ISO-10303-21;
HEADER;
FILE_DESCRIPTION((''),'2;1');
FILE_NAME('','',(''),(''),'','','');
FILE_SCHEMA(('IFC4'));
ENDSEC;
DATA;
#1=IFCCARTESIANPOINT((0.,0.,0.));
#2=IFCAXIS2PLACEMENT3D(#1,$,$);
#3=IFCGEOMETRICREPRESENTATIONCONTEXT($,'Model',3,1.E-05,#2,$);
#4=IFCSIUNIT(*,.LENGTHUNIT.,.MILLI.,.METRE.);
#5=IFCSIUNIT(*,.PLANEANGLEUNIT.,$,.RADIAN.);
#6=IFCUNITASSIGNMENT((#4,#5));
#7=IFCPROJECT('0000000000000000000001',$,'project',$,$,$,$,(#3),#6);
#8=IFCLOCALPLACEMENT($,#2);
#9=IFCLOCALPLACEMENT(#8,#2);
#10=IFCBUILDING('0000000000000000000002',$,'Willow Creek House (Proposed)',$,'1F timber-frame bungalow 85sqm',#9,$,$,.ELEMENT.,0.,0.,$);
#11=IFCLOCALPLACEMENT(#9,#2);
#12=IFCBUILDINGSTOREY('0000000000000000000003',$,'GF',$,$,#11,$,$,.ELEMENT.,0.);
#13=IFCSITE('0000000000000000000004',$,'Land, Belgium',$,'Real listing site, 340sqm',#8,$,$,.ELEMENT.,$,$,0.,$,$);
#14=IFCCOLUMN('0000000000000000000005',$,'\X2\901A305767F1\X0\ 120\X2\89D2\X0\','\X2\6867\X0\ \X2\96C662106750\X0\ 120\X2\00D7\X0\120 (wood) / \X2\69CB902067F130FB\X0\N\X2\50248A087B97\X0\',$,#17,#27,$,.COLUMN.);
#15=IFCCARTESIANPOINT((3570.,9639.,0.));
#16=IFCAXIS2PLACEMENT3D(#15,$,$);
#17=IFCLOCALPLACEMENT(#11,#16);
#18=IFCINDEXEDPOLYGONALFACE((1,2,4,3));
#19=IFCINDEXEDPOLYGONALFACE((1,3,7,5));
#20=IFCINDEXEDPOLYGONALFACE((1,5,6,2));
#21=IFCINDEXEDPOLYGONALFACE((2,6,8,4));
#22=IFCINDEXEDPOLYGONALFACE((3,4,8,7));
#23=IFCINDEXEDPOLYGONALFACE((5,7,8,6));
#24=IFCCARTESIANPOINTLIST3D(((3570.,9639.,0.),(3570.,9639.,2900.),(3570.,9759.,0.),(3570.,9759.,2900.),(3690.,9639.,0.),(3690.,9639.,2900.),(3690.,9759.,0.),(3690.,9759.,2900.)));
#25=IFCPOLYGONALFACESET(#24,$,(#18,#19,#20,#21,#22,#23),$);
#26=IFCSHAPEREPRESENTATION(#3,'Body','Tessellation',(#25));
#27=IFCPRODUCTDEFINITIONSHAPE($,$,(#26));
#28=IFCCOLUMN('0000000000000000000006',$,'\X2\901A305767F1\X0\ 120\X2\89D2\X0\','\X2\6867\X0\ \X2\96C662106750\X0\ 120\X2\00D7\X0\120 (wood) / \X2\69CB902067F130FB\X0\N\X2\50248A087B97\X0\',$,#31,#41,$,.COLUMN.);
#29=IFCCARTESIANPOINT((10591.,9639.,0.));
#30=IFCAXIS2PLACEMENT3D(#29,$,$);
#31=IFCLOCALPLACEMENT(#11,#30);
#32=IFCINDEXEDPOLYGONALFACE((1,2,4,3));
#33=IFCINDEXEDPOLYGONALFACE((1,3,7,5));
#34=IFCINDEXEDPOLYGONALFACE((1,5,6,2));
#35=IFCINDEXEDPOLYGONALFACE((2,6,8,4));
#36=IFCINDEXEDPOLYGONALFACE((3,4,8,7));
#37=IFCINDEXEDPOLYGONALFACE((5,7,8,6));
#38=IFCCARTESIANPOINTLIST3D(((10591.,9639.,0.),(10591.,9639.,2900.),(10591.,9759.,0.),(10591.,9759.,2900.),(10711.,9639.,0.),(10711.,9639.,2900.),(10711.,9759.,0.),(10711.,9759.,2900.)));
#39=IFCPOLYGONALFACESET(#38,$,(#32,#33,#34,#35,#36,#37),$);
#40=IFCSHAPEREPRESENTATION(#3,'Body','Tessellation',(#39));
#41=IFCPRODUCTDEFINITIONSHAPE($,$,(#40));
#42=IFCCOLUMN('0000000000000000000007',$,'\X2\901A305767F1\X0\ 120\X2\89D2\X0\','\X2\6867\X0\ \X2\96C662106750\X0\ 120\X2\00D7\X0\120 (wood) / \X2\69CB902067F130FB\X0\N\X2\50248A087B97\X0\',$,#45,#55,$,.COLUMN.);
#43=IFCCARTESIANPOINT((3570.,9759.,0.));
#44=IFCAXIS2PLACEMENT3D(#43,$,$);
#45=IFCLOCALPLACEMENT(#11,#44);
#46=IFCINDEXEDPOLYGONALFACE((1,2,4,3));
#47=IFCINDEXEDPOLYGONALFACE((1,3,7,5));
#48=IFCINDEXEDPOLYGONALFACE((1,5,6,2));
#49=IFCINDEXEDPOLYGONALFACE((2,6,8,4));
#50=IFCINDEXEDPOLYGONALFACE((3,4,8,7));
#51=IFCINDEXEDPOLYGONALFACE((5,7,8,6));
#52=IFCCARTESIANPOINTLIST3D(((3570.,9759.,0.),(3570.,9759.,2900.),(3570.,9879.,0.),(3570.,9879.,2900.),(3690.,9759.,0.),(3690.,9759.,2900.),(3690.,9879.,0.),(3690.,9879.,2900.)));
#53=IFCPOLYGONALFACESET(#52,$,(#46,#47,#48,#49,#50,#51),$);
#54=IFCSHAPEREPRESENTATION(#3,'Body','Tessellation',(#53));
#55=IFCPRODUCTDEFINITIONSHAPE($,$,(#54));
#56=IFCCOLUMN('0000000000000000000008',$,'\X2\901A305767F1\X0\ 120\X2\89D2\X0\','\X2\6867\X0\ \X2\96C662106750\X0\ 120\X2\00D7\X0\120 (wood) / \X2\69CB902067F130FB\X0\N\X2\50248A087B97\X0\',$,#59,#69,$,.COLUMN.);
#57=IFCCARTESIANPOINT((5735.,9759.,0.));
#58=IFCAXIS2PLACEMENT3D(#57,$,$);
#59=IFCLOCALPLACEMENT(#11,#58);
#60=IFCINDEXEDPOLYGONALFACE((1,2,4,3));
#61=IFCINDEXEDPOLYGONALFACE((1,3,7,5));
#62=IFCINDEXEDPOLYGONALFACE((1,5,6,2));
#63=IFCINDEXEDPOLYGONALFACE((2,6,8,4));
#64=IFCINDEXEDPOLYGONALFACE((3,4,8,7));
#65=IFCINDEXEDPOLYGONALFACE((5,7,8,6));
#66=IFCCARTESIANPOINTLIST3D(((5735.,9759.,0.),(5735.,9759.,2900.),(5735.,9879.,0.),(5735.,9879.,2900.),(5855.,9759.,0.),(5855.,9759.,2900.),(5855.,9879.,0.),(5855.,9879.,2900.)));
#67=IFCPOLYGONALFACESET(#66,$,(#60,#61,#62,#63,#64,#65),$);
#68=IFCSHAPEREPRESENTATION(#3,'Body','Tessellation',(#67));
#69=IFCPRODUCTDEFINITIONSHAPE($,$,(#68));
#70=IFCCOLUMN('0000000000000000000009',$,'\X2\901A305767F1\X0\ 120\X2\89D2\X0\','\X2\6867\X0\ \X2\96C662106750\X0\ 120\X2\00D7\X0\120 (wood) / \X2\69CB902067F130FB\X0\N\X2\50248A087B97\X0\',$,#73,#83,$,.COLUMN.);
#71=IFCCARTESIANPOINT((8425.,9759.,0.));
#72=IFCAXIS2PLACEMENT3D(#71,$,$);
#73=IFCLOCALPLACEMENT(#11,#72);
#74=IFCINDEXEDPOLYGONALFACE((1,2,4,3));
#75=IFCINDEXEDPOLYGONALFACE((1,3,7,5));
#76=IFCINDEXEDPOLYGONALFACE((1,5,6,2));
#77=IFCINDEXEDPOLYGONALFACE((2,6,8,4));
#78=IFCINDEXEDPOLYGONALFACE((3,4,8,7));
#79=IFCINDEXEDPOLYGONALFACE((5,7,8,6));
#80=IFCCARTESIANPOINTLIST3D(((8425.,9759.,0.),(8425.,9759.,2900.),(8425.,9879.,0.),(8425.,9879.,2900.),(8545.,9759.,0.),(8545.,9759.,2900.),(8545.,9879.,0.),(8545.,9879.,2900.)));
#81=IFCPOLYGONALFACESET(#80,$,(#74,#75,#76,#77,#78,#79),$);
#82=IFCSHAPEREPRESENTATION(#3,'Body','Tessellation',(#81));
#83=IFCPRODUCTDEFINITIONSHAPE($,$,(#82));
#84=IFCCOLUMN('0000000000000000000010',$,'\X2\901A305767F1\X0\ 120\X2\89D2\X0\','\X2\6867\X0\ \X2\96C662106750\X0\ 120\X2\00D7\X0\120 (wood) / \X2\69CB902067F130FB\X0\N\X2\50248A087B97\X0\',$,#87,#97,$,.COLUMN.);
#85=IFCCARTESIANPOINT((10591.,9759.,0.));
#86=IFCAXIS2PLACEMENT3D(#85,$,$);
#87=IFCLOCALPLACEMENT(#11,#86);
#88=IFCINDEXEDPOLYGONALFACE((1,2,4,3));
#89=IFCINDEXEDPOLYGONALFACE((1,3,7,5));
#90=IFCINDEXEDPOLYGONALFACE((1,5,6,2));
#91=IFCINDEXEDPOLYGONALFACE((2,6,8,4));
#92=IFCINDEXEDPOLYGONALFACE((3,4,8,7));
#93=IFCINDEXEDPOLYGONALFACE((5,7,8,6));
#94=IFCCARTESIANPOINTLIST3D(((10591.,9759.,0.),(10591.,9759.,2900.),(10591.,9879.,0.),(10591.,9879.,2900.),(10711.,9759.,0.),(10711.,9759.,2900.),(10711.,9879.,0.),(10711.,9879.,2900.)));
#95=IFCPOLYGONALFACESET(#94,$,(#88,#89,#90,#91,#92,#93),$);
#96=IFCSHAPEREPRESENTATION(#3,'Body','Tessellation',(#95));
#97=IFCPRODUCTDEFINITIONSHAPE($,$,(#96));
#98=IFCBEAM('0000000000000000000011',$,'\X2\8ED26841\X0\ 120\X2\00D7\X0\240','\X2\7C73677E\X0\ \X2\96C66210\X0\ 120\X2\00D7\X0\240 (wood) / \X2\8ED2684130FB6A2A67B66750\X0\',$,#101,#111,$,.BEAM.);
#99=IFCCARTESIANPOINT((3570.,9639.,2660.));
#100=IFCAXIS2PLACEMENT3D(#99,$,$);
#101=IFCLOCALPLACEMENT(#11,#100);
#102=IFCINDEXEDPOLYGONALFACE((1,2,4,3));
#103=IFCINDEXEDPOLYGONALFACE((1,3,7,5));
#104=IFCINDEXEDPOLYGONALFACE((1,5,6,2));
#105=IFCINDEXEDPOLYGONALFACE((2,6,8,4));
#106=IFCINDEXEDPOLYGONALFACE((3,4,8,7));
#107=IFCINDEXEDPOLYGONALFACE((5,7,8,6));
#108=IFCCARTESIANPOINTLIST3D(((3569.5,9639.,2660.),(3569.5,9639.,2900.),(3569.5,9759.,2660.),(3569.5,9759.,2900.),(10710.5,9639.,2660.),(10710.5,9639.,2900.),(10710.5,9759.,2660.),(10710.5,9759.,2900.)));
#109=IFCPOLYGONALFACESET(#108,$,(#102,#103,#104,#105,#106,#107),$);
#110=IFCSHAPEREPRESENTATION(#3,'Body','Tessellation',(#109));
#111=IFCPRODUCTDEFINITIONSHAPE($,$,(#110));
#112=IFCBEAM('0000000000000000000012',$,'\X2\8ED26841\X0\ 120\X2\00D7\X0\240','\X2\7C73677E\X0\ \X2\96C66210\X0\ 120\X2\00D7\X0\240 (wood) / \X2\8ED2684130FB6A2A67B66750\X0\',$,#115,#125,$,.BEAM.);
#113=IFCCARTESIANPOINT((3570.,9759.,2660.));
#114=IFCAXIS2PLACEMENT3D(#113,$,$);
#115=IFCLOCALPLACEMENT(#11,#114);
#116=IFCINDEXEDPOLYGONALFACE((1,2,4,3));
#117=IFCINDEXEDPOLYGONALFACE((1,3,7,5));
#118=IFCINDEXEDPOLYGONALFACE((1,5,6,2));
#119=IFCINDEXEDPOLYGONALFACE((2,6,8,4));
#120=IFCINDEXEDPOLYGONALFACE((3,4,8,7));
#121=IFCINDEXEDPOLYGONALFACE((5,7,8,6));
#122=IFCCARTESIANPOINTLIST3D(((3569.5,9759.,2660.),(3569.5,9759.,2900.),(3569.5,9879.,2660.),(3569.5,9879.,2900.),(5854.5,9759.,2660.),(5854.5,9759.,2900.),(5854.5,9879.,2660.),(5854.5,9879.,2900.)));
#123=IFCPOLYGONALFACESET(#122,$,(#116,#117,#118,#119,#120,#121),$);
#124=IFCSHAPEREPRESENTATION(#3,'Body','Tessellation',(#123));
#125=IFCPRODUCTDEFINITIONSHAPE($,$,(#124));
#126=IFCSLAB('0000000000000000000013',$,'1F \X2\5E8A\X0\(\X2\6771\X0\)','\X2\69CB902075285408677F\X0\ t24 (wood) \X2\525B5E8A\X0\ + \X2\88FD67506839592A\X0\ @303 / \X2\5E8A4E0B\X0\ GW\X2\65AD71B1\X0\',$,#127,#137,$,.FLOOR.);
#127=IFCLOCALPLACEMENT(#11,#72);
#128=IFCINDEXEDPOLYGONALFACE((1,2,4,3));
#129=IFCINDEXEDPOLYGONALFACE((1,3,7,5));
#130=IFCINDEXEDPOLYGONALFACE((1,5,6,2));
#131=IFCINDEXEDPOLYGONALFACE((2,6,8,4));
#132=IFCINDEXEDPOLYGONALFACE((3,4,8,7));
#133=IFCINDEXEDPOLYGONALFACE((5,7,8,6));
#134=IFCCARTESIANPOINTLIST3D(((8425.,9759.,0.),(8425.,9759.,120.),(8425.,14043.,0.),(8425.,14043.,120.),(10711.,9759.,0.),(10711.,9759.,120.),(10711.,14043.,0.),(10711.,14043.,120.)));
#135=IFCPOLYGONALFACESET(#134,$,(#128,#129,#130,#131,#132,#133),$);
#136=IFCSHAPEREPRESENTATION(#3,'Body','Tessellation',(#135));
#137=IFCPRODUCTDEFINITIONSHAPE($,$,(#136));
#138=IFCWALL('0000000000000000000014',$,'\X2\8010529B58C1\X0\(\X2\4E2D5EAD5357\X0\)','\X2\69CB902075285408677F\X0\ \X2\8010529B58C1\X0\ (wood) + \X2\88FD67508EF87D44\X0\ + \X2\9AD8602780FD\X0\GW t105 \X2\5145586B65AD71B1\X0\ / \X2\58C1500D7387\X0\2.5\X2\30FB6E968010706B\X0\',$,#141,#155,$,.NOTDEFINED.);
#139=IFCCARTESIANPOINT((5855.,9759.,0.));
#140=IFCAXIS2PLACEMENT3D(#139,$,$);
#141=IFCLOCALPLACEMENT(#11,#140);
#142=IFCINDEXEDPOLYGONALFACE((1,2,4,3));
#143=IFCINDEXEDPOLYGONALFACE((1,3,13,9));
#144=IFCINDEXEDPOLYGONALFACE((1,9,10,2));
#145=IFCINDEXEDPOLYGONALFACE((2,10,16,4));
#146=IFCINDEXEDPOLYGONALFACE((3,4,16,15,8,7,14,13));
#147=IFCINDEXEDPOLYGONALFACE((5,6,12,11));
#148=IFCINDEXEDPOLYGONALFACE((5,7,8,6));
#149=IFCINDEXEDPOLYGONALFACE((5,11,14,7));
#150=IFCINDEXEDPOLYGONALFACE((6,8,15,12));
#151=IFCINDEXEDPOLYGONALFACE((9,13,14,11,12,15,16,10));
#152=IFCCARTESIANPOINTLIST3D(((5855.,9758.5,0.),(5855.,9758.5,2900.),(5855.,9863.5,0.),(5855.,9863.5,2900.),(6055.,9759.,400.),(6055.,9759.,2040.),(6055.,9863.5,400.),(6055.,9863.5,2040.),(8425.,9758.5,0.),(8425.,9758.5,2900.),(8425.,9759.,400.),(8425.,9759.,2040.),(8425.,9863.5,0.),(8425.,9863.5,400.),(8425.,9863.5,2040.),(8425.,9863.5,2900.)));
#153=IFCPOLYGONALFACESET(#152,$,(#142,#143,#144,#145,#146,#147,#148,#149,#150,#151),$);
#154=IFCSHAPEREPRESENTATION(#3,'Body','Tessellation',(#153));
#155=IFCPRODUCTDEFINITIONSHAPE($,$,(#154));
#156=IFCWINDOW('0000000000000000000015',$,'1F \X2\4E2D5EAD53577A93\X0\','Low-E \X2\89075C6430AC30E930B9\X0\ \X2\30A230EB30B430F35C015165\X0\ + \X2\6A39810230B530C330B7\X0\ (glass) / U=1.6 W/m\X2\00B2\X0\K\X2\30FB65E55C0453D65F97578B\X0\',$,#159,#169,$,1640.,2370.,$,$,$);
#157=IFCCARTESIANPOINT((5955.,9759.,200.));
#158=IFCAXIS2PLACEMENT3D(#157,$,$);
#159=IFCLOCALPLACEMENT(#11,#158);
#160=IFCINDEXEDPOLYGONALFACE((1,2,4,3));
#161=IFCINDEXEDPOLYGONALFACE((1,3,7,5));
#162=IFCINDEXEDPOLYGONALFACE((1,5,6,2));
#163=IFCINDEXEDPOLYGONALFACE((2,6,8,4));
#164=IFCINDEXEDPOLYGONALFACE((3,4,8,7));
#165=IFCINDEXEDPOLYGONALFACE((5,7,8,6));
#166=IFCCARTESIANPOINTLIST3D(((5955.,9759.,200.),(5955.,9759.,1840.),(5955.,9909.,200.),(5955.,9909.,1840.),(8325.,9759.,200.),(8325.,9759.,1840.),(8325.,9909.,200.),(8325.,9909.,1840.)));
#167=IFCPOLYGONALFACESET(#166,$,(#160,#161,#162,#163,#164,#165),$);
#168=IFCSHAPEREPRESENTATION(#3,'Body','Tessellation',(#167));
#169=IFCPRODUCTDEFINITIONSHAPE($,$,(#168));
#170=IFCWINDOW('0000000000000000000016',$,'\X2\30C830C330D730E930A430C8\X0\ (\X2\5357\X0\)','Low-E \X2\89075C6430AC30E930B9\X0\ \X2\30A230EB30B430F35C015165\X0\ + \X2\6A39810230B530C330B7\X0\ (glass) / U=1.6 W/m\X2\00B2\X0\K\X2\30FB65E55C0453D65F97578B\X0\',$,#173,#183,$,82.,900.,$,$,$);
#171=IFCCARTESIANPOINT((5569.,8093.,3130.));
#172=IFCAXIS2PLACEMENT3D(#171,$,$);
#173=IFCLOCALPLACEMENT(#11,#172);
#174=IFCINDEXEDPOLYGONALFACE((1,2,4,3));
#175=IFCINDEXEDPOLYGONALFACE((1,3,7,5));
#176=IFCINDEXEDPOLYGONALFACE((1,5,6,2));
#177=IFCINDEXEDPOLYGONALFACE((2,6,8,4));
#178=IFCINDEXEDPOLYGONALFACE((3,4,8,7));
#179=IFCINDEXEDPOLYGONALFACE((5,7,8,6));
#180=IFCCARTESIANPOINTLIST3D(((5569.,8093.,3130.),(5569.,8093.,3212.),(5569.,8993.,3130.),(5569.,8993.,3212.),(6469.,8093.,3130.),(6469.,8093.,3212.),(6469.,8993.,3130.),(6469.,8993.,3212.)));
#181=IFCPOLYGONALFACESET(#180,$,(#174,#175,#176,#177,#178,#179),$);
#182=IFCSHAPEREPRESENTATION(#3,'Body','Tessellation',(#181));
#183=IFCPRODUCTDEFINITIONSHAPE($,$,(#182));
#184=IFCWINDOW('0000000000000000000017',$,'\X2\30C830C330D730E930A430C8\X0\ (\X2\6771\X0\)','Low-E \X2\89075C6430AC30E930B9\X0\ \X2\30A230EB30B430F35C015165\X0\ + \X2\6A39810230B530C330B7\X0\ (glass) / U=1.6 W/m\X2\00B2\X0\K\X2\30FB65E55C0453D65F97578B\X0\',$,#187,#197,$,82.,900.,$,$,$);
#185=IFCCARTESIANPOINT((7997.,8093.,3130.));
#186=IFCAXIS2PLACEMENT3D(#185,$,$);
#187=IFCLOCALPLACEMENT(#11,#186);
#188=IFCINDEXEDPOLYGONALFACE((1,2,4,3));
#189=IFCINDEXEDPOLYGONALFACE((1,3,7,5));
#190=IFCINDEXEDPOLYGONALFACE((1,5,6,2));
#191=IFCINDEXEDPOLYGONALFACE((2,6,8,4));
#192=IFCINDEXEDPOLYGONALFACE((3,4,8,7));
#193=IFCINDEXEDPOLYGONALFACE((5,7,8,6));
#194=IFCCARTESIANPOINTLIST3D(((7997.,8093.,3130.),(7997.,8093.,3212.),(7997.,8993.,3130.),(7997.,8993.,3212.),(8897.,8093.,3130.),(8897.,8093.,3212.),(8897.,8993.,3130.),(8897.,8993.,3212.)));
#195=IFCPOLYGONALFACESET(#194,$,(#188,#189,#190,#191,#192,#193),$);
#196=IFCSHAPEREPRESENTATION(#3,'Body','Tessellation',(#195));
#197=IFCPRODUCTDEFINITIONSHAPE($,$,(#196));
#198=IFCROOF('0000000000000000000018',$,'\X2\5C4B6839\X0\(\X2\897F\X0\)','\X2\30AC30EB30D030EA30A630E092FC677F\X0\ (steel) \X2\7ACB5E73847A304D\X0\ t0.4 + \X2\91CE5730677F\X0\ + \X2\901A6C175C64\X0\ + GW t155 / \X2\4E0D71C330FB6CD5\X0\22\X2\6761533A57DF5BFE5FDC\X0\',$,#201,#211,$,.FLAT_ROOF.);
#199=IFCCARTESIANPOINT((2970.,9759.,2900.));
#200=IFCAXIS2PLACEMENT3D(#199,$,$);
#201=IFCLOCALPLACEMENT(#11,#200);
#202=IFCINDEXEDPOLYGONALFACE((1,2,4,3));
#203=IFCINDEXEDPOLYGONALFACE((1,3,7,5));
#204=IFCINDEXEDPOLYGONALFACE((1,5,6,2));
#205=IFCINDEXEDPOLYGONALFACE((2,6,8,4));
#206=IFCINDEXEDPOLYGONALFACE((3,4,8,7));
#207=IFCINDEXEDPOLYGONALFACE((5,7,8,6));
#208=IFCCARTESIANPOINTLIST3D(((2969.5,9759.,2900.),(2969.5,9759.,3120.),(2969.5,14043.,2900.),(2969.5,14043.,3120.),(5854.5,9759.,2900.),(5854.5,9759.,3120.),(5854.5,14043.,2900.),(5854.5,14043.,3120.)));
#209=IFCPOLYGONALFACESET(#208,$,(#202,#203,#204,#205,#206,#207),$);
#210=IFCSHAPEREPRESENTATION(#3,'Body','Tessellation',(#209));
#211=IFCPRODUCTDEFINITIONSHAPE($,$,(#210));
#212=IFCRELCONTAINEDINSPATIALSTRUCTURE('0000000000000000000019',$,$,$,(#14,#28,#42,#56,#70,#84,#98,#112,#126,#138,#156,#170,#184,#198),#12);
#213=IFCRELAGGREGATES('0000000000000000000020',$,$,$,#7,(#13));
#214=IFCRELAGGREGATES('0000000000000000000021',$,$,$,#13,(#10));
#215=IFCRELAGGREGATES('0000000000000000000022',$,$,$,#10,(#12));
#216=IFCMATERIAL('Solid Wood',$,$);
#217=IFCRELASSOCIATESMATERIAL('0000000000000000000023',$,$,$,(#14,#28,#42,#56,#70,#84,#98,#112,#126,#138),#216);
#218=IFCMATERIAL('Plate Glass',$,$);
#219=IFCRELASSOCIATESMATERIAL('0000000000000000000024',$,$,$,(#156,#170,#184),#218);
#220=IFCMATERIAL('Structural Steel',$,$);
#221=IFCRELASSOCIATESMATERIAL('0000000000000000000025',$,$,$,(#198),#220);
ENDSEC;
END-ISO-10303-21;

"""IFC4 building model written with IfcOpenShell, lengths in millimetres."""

from ifc_helpers import new_model, si_unit, frame, frame_2d, origin, place, context, project, spatial, rectangle, extrude, material, element, fill, save


model = new_model("IFC4")

# Units and contexts
model_context = context("Model", 3, precision=1e-05, world=origin())
ifc_project = project(units=[si_unit("LENGTHUNIT", "METRE", prefix="MILLI"), si_unit("PLANEANGLEUNIT", "RADIAN")], contexts=[model_context])

# Site, building, storey
site_placement = place(None, origin())
site = spatial("IfcSite", under=ifc_project, at=site_placement, Name="Land, Belgium", ObjectType="Real listing site, 340sqm", CompositionType="ELEMENT", RefElevation=0.0)
building_placement = place(site_placement, origin())
building = spatial("IfcBuilding", under=site, at=building_placement, Name="Willow Creek House (Proposed)", ObjectType="1F timber-frame bungalow 85sqm", CompositionType="ELEMENT", ElevationOfRefHeight=0.0, ElevationOfTerrain=0.0)
storey_placement = place(building_placement, origin())
storey = spatial("IfcBuildingStorey", under=building, at=storey_placement, Name="GF", CompositionType="ELEMENT", Elevation=0.0)

# Columns
ifc_material_1 = material(Name="Solid Wood")
column_1_placement = place(storey_placement, frame((3570.0, 9639.0, 0.0)))
element("IfcColumn", 1, at=column_1_placement, inside=storey, material=ifc_material_1, Name="通し柱 120角", Description="桧 集成材 120×120 (wood) / 構造柱・N値計算", PredefinedType="COLUMN", context=model_context, shape_type="SweptSolid", body=[
    extrude(rectangle(XDim=120.0, YDim=120.0, at=frame_2d((60.0, 60.0))), frame((3570.0, 9639.0, 0.0)), (0.0, 0.0, 1.0), 2900.0),
])
column_2_placement = place(storey_placement, frame((10591.0, 9639.0, 0.0)))
element("IfcColumn", 2, at=column_2_placement, inside=storey, material=ifc_material_1, Name="通し柱 120角", Description="桧 集成材 120×120 (wood) / 構造柱・N値計算", PredefinedType="COLUMN", context=model_context, shape_type="SweptSolid", body=[
    extrude(rectangle(XDim=120.0, YDim=120.0, at=frame_2d((60.0, 60.0))), frame((10591.0, 9639.0, 0.0)), (0.0, 0.0, 1.0), 2900.0),
])
column_3_placement = place(storey_placement, frame((3570.0, 9759.0, 0.0)))
element("IfcColumn", 3, at=column_3_placement, inside=storey, material=ifc_material_1, Name="通し柱 120角", Description="桧 集成材 120×120 (wood) / 構造柱・N値計算", PredefinedType="COLUMN", context=model_context, shape_type="SweptSolid", body=[
    extrude(rectangle(XDim=120.0, YDim=120.0, at=frame_2d((60.0, 60.0))), frame((3570.0, 9759.0, 0.0)), (0.0, 0.0, 1.0), 2900.0),
])
column_4_placement = place(storey_placement, frame((5735.0, 9759.0, 0.0)))
element("IfcColumn", 4, at=column_4_placement, inside=storey, material=ifc_material_1, Name="通し柱 120角", Description="桧 集成材 120×120 (wood) / 構造柱・N値計算", PredefinedType="COLUMN", context=model_context, shape_type="SweptSolid", body=[
    extrude(rectangle(XDim=120.0, YDim=120.0, at=frame_2d((60.0, 60.0))), frame((5735.0, 9759.0, 0.0)), (0.0, 0.0, 1.0), 2900.0),
])
column_5_placement = place(storey_placement, frame((8425.0, 9759.0, 0.0)))
element("IfcColumn", 5, at=column_5_placement, inside=storey, material=ifc_material_1, Name="通し柱 120角", Description="桧 集成材 120×120 (wood) / 構造柱・N値計算", PredefinedType="COLUMN", context=model_context, shape_type="SweptSolid", body=[
    extrude(rectangle(XDim=120.0, YDim=120.0, at=frame_2d((60.0, 60.0))), frame((8425.0, 9759.0, 0.0)), (0.0, 0.0, 1.0), 2900.0),
])
column_6_placement = place(storey_placement, frame((10591.0, 9759.0, 0.0)))
element("IfcColumn", 6, at=column_6_placement, inside=storey, material=ifc_material_1, Name="通し柱 120角", Description="桧 集成材 120×120 (wood) / 構造柱・N値計算", PredefinedType="COLUMN", context=model_context, shape_type="SweptSolid", body=[
    extrude(rectangle(XDim=120.0, YDim=120.0, at=frame_2d((60.0, 60.0))), frame((10591.0, 9759.0, 0.0)), (0.0, 0.0, 1.0), 2900.0),
])

# Beams
beam_1_placement = place(storey_placement, frame((3570.0, 9639.0, 2660.0)))
element("IfcBeam", 7, at=beam_1_placement, inside=storey, material=ifc_material_1, Name="軒桁 120×240", Description="米松 集成 120×240 (wood) / 軒桁・横架材", PredefinedType="BEAM", context=model_context, shape_type="SweptSolid", body=[
    extrude(rectangle(XDim=7141.0, YDim=120.0, at=frame_2d((3570.0, 60.0))), frame((3570.0, 9639.0, 2660.0)), (0.0, 0.0, 1.0), 240.0),
])
beam_2_placement = place(storey_placement, frame((3570.0, 9759.0, 2660.0)))
element("IfcBeam", 8, at=beam_2_placement, inside=storey, material=ifc_material_1, Name="軒桁 120×240", Description="米松 集成 120×240 (wood) / 軒桁・横架材", PredefinedType="BEAM", context=model_context, shape_type="SweptSolid", body=[
    extrude(rectangle(XDim=2285.0, YDim=120.0, at=frame_2d((1142.0, 60.0))), frame((3570.0, 9759.0, 2660.0)), (0.0, 0.0, 1.0), 240.0),
])

# Slab
slab_1_placement = place(storey_placement, frame((8425.0, 9759.0, 0.0)))
element("IfcSlab", 9, at=slab_1_placement, inside=storey, material=ifc_material_1, Name="1F 床(東)", Description="構造用合板 t24 (wood) 剛床 + 製材根太 @303 / 床下 GW断熱", PredefinedType="FLOOR", context=model_context, shape_type="SweptSolid", body=[
    extrude(rectangle(XDim=2286.0, YDim=4284.0, at=frame_2d((1143.0, 2142.0))), frame((8425.0, 9759.0, 0.0)), (0.0, 0.0, 1.0), 120.0),
])

# Wall, opening, window
wall_1_placement = place(storey_placement, frame((5855.0, 9759.0, 0.0)))
wall_1 = element("IfcWall", 10, at=wall_1_placement, inside=storey, material=ifc_material_1, Name="耐力壁(中庭南)", Description="構造用合板 耐力壁 (wood) + 製材軸組 + 高性能GW t105 充填断熱 / 壁倍率2.5・準耐火", PredefinedType="NOTDEFINED", context=model_context, shape_type="SweptSolid", body=[
    extrude(rectangle(XDim=2570.0, YDim=105.0, at=frame_2d((1285.0, 52.0))), frame((5855.0, 9759.0, 0.0)), (0.0, 0.0, 1.0), 2900.0),
])
opening_placement = place(storey_placement, frame((5955.0, 9759.0, 200.0)))
opening = element("IfcOpeningElement", 11, at=opening_placement, cuts=wall_1, PredefinedType="NOTDEFINED", context=model_context, shape_type="SweptSolid", body=[
    extrude(rectangle(XDim=2370.0, YDim=150.0, at=frame_2d((1185.0, 75.0))), frame((5955.0, 9759.0, 200.0)), (0.0, 0.0, 1.0), 1640.0),
])
ifc_material_2 = material(Name="Plate Glass")
window_1_placement = place(storey_placement, frame((5955.0, 9759.0, 200.0)))
window_1 = element("IfcWindow", 12, at=window_1_placement, inside=storey, material=ifc_material_2, Name="1F 中庭南窓", Description="Low-E 複層ガラス アルゴン封入 + 樹脂サッシ (glass) / U=1.6 W/m²K・日射取得型", OverallHeight=1640.0, OverallWidth=2370.0, context=model_context, shape_type="SweptSolid", body=[
    extrude(rectangle(XDim=2370.0, YDim=150.0, at=frame_2d((1185.0, 75.0))), frame((5955.0, 9759.0, 200.0)), (0.0, 0.0, 1.0), 1640.0),
])
fill(opening, window_1)

# Windows
window_2_placement = place(storey_placement, frame((5569.0, 8093.0, 3130.0)))
element("IfcWindow", 13, at=window_2_placement, inside=storey, material=ifc_material_2, Name="トップライト (南)", Description="Low-E 複層ガラス アルゴン封入 + 樹脂サッシ (glass) / U=1.6 W/m²K・日射取得型", OverallHeight=82.0, OverallWidth=900.0, context=model_context, shape_type="SweptSolid", body=[
    extrude(rectangle(XDim=900.0, YDim=900.0, at=frame_2d((450.0, 450.0))), frame((5569.0, 8093.0, 3130.0)), (0.0, 0.0, 1.0), 82.0),
])
window_3_placement = place(storey_placement, frame((7997.0, 8093.0, 3130.0)))
element("IfcWindow", 14, at=window_3_placement, inside=storey, material=ifc_material_2, Name="トップライト (東)", Description="Low-E 複層ガラス アルゴン封入 + 樹脂サッシ (glass) / U=1.6 W/m²K・日射取得型", OverallHeight=82.0, OverallWidth=900.0, context=model_context, shape_type="SweptSolid", body=[
    extrude(rectangle(XDim=900.0, YDim=900.0, at=frame_2d((450.0, 450.0))), frame((7997.0, 8093.0, 3130.0)), (0.0, 0.0, 1.0), 82.0),
])

# Roof
ifc_material_3 = material(Name="Structural Steel")
roof_1_placement = place(storey_placement, frame((2970.0, 9759.0, 2900.0)))
element("IfcRoof", 15, at=roof_1_placement, inside=storey, material=ifc_material_3, Name="屋根(西)", Description="ガルバリウム鋼板 (steel) 立平葺き t0.4 + 野地板 + 通気層 + GW t155 / 不燃・法22条区域対応", PredefinedType="FLAT_ROOF", context=model_context, shape_type="SweptSolid", body=[
    extrude(rectangle(XDim=2885.0, YDim=4284.0, at=frame_2d((1442.0, 2142.0))), frame((2970.0, 9759.0, 2900.0)), (0.0, 0.0, 1.0), 220.0),
])

save(model, "model.ifc")
